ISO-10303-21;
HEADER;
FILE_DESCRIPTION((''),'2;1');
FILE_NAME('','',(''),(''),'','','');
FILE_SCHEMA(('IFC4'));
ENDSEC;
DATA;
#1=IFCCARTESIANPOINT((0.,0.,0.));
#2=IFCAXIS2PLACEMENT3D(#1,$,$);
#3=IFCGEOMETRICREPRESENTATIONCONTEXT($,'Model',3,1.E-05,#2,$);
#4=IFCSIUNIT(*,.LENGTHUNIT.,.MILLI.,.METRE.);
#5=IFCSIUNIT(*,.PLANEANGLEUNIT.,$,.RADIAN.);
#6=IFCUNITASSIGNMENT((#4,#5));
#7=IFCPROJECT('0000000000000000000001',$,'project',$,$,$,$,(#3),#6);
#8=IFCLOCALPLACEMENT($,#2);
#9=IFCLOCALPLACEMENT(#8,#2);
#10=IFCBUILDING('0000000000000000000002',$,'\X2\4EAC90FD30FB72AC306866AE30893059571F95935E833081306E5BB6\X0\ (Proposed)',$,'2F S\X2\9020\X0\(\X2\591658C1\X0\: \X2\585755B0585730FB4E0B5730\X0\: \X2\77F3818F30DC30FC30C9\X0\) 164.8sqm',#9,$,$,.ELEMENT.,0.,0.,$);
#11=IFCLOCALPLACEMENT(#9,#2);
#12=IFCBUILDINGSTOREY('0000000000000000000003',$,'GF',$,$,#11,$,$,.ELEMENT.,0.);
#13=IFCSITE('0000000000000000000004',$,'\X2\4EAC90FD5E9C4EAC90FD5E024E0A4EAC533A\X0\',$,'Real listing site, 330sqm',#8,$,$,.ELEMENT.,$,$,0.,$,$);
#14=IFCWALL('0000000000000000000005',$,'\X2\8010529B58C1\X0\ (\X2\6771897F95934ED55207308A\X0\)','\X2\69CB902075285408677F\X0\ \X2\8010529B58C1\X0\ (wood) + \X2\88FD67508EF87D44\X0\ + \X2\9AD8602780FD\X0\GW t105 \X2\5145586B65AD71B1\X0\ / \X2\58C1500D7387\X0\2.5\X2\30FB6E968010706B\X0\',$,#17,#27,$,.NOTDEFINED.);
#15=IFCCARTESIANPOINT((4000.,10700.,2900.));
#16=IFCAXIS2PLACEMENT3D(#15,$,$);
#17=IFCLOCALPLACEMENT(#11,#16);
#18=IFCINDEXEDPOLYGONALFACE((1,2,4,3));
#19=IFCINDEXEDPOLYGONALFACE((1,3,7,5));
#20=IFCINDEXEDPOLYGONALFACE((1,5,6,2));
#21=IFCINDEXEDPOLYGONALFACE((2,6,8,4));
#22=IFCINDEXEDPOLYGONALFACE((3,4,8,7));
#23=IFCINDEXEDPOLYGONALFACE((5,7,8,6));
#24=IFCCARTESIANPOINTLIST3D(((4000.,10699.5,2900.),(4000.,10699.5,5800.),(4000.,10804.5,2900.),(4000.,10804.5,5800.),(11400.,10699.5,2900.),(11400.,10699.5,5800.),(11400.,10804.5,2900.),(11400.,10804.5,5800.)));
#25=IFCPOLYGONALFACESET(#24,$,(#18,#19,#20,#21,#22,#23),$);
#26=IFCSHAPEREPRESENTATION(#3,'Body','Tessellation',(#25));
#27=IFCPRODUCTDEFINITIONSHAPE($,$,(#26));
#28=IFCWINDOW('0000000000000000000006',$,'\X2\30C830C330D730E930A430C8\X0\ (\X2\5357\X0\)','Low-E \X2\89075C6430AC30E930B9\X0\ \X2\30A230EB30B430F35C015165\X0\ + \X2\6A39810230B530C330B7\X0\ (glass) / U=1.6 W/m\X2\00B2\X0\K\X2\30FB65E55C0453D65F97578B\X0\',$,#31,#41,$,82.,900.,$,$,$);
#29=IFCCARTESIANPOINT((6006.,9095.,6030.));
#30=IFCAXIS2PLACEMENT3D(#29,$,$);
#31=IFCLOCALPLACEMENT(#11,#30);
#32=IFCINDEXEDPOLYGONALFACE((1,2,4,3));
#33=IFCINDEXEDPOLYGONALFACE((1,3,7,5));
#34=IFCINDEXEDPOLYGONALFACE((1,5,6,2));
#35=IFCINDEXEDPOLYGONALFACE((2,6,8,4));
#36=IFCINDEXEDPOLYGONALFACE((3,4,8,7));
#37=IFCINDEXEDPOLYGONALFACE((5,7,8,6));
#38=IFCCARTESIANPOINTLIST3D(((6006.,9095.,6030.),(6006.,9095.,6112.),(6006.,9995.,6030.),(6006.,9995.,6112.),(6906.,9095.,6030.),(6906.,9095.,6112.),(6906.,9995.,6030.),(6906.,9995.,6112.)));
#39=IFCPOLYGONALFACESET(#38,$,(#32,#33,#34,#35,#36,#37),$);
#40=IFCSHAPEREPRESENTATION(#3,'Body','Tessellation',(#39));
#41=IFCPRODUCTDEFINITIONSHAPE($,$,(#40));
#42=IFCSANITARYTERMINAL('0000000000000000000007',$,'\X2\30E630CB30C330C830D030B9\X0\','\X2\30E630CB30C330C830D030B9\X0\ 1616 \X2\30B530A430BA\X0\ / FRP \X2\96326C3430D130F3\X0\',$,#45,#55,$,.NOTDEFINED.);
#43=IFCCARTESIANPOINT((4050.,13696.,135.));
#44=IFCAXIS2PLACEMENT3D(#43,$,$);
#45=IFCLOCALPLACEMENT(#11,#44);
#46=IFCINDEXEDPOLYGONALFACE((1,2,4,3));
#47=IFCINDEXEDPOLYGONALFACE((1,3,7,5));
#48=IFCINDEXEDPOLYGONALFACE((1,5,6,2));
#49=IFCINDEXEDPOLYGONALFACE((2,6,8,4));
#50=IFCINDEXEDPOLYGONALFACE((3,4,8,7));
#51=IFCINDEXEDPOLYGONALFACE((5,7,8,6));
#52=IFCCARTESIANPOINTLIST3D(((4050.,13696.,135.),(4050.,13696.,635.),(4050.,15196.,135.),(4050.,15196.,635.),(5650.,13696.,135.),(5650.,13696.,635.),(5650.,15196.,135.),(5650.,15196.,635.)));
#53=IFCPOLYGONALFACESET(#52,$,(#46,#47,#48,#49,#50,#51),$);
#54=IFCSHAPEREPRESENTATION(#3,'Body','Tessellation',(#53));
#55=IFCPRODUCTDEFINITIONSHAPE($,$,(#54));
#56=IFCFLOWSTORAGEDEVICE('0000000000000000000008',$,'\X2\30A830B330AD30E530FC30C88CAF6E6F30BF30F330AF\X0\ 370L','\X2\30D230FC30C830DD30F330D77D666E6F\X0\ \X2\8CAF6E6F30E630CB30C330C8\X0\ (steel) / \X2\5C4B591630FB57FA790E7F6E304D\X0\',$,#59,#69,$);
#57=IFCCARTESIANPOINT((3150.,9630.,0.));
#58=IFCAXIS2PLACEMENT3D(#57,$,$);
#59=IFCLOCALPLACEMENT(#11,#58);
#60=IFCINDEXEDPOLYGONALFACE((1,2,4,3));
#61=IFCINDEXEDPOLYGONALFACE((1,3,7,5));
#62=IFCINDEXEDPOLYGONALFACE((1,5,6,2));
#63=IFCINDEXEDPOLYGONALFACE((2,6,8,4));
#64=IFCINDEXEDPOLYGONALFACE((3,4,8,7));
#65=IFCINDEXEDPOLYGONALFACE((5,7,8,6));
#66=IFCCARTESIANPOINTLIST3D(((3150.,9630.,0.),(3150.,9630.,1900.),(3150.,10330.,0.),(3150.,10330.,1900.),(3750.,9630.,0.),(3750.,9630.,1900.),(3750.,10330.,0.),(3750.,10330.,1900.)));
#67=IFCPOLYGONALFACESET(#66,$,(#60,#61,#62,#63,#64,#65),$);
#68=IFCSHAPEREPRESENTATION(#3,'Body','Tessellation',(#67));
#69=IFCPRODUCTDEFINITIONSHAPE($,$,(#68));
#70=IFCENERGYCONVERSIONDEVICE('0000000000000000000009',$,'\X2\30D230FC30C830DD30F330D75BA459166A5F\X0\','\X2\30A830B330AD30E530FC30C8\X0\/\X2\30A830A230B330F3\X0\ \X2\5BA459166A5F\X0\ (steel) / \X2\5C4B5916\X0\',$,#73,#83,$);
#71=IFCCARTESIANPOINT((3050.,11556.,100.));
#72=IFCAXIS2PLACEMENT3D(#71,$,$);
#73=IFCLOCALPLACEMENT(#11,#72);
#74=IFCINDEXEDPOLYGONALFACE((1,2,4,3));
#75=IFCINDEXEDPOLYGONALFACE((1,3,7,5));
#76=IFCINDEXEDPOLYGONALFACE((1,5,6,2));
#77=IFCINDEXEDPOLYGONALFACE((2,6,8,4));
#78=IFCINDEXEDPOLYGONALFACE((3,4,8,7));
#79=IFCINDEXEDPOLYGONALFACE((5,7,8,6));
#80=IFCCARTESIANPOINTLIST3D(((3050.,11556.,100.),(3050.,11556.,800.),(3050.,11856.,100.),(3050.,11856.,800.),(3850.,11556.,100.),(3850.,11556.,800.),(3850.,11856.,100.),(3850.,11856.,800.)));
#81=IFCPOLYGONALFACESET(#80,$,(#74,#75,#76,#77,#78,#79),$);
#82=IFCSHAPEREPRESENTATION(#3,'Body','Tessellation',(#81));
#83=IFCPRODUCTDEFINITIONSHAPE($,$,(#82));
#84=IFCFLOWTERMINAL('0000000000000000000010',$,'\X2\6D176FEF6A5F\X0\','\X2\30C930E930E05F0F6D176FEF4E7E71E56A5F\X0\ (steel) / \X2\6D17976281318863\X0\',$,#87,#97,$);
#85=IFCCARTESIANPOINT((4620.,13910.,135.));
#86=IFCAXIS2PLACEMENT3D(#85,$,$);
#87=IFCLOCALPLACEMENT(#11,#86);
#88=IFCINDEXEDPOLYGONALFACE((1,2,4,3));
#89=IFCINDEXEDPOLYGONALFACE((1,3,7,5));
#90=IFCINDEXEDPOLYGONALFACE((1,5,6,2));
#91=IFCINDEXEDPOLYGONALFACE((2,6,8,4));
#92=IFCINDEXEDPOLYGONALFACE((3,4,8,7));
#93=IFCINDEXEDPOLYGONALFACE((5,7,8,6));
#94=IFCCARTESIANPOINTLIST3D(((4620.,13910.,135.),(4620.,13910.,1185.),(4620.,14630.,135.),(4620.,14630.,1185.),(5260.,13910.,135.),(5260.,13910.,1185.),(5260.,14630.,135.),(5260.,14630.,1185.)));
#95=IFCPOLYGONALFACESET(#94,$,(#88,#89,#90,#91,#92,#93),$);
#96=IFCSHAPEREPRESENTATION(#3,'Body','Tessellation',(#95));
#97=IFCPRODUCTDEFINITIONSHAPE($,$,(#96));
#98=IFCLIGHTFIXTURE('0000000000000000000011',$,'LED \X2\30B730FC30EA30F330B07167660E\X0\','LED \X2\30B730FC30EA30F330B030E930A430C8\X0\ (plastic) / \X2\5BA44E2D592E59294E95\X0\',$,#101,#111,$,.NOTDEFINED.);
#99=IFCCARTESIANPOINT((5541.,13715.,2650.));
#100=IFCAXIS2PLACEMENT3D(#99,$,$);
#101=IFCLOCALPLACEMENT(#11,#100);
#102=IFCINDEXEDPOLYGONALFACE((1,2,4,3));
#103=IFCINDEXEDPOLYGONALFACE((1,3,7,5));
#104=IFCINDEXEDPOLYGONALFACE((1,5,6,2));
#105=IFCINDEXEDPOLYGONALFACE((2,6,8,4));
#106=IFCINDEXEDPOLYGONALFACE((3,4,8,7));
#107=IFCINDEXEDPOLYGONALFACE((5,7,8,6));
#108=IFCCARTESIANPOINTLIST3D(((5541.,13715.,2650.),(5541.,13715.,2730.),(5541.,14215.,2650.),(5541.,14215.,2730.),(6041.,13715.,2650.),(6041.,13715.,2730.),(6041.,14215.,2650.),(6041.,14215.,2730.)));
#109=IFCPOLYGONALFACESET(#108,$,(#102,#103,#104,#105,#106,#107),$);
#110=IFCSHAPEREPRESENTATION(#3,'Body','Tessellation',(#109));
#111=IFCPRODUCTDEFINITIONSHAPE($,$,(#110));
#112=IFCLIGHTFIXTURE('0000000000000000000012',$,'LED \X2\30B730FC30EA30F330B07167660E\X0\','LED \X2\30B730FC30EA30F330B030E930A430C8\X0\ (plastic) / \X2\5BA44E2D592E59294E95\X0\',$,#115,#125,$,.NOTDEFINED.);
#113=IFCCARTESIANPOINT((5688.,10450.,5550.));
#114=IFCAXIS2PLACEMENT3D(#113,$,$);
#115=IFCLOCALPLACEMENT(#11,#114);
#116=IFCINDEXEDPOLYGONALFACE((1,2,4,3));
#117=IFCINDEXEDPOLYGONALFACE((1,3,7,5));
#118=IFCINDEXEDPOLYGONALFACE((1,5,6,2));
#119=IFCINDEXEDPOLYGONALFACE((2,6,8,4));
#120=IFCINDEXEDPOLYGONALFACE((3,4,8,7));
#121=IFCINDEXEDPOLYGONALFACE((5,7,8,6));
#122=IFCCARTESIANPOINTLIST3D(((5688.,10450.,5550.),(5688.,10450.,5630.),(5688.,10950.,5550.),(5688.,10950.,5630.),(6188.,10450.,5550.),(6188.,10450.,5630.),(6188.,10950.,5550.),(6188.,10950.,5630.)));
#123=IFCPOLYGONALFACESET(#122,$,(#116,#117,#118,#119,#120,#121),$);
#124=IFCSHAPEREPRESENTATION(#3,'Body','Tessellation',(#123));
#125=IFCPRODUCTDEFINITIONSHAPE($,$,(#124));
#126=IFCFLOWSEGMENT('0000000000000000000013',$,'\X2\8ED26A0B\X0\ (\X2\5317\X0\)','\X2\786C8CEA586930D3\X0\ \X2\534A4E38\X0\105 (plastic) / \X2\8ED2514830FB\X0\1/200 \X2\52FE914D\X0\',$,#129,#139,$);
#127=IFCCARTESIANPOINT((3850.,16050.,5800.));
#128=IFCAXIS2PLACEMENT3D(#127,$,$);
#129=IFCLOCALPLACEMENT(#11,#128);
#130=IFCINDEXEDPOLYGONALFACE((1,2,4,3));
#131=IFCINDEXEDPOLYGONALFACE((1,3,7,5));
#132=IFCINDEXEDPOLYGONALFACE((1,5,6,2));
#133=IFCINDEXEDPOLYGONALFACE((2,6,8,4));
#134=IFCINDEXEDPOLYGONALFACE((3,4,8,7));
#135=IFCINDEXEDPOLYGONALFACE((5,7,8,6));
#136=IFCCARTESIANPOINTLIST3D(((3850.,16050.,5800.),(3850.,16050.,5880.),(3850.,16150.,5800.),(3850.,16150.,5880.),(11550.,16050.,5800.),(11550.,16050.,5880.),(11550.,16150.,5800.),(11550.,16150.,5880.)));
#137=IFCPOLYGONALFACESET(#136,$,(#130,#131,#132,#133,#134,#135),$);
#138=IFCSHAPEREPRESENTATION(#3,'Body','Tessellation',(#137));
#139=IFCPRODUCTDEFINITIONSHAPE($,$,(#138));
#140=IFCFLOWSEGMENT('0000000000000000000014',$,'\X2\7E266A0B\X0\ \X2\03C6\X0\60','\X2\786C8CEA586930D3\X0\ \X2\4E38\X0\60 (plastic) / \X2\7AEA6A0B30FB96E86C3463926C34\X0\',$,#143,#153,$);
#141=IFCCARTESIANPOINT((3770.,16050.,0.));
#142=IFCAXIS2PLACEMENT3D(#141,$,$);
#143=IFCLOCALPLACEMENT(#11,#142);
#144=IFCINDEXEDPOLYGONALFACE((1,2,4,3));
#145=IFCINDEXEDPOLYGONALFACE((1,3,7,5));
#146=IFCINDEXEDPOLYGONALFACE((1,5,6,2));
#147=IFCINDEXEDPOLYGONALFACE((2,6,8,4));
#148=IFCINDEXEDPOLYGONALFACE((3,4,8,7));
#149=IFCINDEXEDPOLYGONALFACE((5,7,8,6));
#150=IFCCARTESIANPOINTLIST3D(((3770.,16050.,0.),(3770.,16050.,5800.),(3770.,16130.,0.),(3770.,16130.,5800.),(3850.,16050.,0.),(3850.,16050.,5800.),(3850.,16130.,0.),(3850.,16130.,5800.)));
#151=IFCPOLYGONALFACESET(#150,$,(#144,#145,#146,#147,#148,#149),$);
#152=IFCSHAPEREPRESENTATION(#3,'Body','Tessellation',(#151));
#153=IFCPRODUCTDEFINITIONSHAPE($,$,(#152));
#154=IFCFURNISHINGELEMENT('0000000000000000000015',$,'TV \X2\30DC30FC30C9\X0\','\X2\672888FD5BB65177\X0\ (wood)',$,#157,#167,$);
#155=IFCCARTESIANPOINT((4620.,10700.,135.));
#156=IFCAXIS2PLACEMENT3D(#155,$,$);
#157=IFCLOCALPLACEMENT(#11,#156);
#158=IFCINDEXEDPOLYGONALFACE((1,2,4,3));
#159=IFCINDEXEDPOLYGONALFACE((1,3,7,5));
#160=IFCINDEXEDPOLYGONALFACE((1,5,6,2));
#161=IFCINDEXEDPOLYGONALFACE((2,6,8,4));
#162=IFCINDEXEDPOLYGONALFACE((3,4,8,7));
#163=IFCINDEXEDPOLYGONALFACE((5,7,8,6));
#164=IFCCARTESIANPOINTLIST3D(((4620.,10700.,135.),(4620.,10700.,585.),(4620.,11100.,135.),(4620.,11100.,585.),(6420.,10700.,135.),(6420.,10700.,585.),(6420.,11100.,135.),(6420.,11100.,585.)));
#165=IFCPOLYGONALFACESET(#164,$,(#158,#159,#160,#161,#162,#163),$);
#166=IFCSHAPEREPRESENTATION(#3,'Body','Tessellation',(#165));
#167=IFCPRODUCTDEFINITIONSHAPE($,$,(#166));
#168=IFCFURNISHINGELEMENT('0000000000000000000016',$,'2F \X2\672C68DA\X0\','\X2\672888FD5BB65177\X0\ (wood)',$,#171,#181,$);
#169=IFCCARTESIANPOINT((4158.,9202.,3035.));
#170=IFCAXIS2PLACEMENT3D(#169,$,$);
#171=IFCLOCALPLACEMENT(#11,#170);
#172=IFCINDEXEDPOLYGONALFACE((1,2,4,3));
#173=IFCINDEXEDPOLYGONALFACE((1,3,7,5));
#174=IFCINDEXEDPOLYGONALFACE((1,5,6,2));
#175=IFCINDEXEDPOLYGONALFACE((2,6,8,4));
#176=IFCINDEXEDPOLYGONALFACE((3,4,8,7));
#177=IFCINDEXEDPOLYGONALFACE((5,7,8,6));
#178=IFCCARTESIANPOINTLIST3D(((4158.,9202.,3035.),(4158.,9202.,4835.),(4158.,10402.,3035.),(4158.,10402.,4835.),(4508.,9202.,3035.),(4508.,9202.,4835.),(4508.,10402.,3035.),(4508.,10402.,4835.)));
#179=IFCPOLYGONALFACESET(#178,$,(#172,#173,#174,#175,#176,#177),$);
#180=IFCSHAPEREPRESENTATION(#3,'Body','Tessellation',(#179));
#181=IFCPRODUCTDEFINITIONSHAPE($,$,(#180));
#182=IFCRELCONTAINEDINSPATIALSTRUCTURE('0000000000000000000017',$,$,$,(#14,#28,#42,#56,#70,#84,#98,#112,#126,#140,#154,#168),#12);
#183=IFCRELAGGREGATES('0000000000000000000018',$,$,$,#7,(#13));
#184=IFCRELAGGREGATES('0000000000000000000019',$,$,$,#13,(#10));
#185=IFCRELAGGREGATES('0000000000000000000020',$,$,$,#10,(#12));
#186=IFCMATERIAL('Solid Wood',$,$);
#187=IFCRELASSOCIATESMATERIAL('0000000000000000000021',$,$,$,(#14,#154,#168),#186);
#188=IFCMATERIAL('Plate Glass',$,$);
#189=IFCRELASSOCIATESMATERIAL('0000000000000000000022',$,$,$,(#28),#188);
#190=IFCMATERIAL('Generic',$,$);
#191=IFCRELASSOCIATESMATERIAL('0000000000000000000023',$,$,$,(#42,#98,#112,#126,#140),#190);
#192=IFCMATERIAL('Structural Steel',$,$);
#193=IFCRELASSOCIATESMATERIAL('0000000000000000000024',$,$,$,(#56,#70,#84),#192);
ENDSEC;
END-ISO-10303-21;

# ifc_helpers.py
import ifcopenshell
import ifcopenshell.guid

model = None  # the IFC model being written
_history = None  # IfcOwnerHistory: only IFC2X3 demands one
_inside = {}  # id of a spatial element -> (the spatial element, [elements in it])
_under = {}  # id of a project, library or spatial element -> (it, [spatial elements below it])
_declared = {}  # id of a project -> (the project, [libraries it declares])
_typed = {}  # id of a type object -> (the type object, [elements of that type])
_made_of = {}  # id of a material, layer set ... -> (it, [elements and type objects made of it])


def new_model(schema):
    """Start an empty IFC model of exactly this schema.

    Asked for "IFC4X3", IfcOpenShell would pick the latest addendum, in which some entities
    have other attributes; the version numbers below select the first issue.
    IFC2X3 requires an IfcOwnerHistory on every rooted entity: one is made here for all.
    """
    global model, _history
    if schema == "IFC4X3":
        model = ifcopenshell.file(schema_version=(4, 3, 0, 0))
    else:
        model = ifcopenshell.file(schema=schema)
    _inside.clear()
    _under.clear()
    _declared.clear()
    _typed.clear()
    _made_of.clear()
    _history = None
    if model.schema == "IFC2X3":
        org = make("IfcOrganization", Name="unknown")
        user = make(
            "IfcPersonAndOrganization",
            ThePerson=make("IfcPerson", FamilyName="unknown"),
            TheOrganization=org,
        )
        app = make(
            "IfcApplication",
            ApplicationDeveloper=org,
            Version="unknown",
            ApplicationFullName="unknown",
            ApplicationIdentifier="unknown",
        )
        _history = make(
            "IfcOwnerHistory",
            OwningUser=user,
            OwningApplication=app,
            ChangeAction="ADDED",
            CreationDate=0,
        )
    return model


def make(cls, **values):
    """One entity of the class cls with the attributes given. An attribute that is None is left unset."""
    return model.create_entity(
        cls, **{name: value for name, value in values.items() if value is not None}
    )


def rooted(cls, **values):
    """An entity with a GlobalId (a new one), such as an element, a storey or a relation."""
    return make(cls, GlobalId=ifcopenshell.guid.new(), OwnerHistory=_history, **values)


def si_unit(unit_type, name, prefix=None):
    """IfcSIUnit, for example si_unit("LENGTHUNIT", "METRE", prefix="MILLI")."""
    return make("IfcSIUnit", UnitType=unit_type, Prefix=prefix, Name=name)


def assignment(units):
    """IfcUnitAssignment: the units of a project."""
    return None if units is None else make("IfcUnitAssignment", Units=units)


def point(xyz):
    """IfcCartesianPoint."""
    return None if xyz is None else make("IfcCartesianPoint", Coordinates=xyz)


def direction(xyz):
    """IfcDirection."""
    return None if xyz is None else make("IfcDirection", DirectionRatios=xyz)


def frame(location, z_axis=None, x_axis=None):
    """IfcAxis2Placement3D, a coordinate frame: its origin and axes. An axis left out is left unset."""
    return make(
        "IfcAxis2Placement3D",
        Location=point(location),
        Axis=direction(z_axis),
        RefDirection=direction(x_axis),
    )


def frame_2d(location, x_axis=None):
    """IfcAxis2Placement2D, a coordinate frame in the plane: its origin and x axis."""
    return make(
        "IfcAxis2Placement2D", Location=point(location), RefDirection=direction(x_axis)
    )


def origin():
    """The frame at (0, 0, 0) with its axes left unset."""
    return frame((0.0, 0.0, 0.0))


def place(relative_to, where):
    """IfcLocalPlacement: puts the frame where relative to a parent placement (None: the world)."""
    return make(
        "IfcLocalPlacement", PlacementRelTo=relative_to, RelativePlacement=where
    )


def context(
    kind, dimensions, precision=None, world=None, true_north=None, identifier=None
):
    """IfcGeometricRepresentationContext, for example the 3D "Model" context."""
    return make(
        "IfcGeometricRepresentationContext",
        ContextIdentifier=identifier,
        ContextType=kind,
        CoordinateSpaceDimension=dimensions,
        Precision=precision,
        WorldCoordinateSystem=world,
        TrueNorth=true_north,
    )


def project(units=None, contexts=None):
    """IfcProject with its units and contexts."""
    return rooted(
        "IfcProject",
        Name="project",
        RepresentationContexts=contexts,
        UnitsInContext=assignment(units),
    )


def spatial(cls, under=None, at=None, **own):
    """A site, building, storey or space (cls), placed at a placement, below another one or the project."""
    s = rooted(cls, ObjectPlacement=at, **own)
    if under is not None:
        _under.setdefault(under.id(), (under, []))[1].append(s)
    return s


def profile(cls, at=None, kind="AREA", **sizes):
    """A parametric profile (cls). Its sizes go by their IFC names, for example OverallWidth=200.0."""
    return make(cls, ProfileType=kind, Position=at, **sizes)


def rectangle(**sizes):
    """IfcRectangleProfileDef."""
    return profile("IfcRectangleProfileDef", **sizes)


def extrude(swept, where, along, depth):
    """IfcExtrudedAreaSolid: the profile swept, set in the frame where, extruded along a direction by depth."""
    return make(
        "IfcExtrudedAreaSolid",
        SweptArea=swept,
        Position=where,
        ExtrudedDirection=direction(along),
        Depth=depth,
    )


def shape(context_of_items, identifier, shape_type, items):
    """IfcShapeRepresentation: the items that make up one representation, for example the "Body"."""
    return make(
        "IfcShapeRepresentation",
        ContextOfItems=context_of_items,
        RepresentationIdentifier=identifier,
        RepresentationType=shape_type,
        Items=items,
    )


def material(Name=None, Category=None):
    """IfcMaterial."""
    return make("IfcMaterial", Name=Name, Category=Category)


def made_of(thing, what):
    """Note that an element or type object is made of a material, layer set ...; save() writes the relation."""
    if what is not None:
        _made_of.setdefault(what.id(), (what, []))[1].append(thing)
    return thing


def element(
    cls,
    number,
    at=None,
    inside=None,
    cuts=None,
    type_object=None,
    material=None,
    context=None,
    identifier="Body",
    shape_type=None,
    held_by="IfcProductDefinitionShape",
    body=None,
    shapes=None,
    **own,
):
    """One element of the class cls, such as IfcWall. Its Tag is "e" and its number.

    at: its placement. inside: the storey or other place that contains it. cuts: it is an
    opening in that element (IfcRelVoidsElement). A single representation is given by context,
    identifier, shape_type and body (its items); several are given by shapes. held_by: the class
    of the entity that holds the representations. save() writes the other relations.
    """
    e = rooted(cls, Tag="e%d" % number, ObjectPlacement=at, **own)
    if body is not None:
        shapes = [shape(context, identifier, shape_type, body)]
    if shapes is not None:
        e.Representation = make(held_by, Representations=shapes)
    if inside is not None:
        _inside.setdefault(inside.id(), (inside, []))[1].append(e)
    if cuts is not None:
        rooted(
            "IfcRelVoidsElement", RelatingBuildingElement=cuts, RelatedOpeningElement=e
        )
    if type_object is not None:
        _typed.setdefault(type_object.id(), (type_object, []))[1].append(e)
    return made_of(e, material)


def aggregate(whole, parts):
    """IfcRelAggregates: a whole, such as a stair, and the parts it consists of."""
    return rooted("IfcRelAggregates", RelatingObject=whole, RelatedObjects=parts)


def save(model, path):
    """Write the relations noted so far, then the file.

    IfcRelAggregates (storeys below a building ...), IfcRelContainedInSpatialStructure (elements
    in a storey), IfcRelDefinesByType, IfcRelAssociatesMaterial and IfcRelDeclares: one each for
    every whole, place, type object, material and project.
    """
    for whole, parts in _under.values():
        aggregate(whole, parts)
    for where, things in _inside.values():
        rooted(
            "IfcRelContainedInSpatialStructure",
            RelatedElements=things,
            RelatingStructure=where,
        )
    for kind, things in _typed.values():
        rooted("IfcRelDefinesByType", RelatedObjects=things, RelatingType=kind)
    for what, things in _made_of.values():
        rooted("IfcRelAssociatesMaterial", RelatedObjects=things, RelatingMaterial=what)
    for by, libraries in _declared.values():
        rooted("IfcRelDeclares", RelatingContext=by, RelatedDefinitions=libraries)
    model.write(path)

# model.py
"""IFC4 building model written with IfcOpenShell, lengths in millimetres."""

from ifc_helpers import new_model, si_unit, frame, frame_2d, origin, place, context, project, spatial, rectangle, extrude, material, element, save


model = new_model("IFC4")

# Units and contexts
model_context = context("Model", 3, precision=1e-05, world=origin())
ifc_project = project(units=[si_unit("LENGTHUNIT", "METRE", prefix="MILLI"), si_unit("PLANEANGLEUNIT", "RADIAN")], contexts=[model_context])

# Site, building, storey
site_placement = place(None, origin())
site = spatial("IfcSite", under=ifc_project, at=site_placement, Name="京都府京都市上京区", ObjectType="Real listing site, 330sqm", CompositionType="ELEMENT", RefElevation=0.0)
building_placement = place(site_placement, origin())
building = spatial("IfcBuilding", under=site, at=building_placement, Name="京都・犬と暮らす土間広めの家 (Proposed)", ObjectType="2F S造(外壁: 塗喰塗・下地: 石膏ボード) 164.8sqm", CompositionType="ELEMENT", ElevationOfRefHeight=0.0, ElevationOfTerrain=0.0)
storey_placement = place(building_placement, origin())
storey = spatial("IfcBuildingStorey", under=building, at=storey_placement, Name="GF", CompositionType="ELEMENT", Elevation=0.0)

# Shared definitions
ifc_material_1 = material(Name="Solid Wood")

# Shared definitions
ifc_material_2 = material(Name="Plate Glass")

# Wall
wall_1_placement = place(storey_placement, frame((4000.0, 10700.0, 2900.0)))
element("IfcWall", 1, at=wall_1_placement, inside=storey, material=ifc_material_1, Name="耐力壁 (東西間仕切り)", Description="構造用合板 耐力壁 (wood) + 製材軸組 + 高性能GW t105 充填断熱 / 壁倍率2.5・準耐火", PredefinedType="NOTDEFINED", context=model_context, shape_type="SweptSolid", body=[
    extrude(rectangle(XDim=7400.0, YDim=105.0, at=frame_2d((3700.0, 52.0))), frame((4000.0, 10700.0, 2900.0)), (0.0, 0.0, 1.0), 2900.0),
])

# Window
window_1_placement = place(storey_placement, frame((6006.0, 9095.0, 6030.0)))
element("IfcWindow", 2, at=window_1_placement, inside=storey, material=ifc_material_2, Name="トップライト (南)", Description="Low-E 複層ガラス アルゴン封入 + 樹脂サッシ (glass) / U=1.6 W/m²K・日射取得型", OverallHeight=82.0, OverallWidth=900.0, context=model_context, shape_type="SweptSolid", body=[
    extrude(rectangle(XDim=900.0, YDim=900.0, at=frame_2d((450.0, 450.0))), frame((6006.0, 9095.0, 6030.0)), (0.0, 0.0, 1.0), 82.0),
])

# Sanitary terminal
ifc_material_3 = material(Name="Generic")
sanitary_terminal_placement = place(storey_placement, frame((4050.0, 13696.0, 135.0)))
element("IfcSanitaryTerminal", 3, at=sanitary_terminal_placement, inside=storey, material=ifc_material_3, Name="ユニットバス", Description="ユニットバス 1616 サイズ / FRP 防水パン", PredefinedType="NOTDEFINED", context=model_context, shape_type="SweptSolid", body=[
    extrude(rectangle(XDim=1600.0, YDim=1500.0, at=frame_2d((800.0, 750.0))), frame((4050.0, 13696.0, 135.0)), (0.0, 0.0, 1.0), 500.0),
])

# Flow storage device
ifc_material_4 = material(Name="Structural Steel")
flow_storage_device_placement = place(storey_placement, frame((3150.0, 9630.0, 0.0)))
element("IfcFlowStorageDevice", 4, at=flow_storage_device_placement, inside=storey, material=ifc_material_4, Name="エコキュート貯湯タンク 370L", Description="ヒートポンプ給湯 貯湯ユニット (steel) / 屋外・基礎置き", context=model_context, shape_type="SweptSolid", body=[
    extrude(rectangle(XDim=600.0, YDim=700.0, at=frame_2d((300.0, 350.0))), frame((3150.0, 9630.0, 0.0)), (0.0, 0.0, 1.0), 1900.0),
])

# Energy conversion device
energy_conversion_device_placement = place(storey_placement, frame((3050.0, 11556.0, 100.0)))
element("IfcEnergyConversionDevice", 5, at=energy_conversion_device_placement, inside=storey, material=ifc_material_4, Name="ヒートポンプ室外機", Description="エコキュート/エアコン 室外機 (steel) / 屋外", context=model_context, shape_type="SweptSolid", body=[
    extrude(rectangle(XDim=800.0, YDim=300.0, at=frame_2d((400.0, 150.0))), frame((3050.0, 11556.0, 100.0)), (0.0, 0.0, 1.0), 700.0),
])

# Flow terminal
flow_terminal_placement = place(storey_placement, frame((4620.0, 13910.0, 135.0)))
element("IfcFlowTerminal", 6, at=flow_terminal_placement, inside=storey, material=ifc_material_4, Name="洗濯機", Description="ドラム式洗濯乾燥機 (steel) / 洗面脱衣", context=model_context, shape_type="SweptSolid", body=[
    extrude(rectangle(XDim=640.0, YDim=720.0, at=frame_2d((320.0, 360.0))), frame((4620.0, 13910.0, 135.0)), (0.0, 0.0, 1.0), 1050.0),
])

# Light fixtures
light_fixture_1_placement = place(storey_placement, frame((5541.0, 13715.0, 2650.0)))
element("IfcLightFixture", 7, at=light_fixture_1_placement, inside=storey, material=ifc_material_3, Name="LED シーリング照明", Description="LED シーリングライト (plastic) / 室中央天井", PredefinedType="NOTDEFINED", context=model_context, shape_type="SweptSolid", body=[
    extrude(rectangle(XDim=500.0, YDim=500.0, at=frame_2d((250.0, 250.0))), frame((5541.0, 13715.0, 2650.0)), (0.0, 0.0, 1.0), 80.0),
])
light_fixture_2_placement = place(storey_placement, frame((5688.0, 10450.0, 5550.0)))
element("IfcLightFixture", 8, at=light_fixture_2_placement, inside=storey, material=ifc_material_3, Name="LED シーリング照明", Description="LED シーリングライト (plastic) / 室中央天井", PredefinedType="NOTDEFINED", context=model_context, shape_type="SweptSolid", body=[
    extrude(rectangle(XDim=500.0, YDim=500.0, at=frame_2d((250.0, 250.0))), frame((5688.0, 10450.0, 5550.0)), (0.0, 0.0, 1.0), 80.0),
])

# Flow segments
flow_segment_1_placement = place(storey_placement, frame((3850.0, 16050.0, 5800.0)))
element("IfcFlowSegment", 9, at=flow_segment_1_placement, inside=storey, material=ifc_material_3, Name="軒樋 (北)", Description="硬質塩ビ 半丸105 (plastic) / 軒先・1/200 勾配", context=model_context, shape_type="SweptSolid", body=[
    extrude(rectangle(XDim=7700.0, YDim=100.0, at=frame_2d((3850.0, 50.0))), frame((3850.0, 16050.0, 5800.0)), (0.0, 0.0, 1.0), 80.0),
])
flow_segment_2_placement = place(storey_placement, frame((3770.0, 16050.0, 0.0)))
element("IfcFlowSegment", 10, at=flow_segment_2_placement, inside=storey, material=ifc_material_3, Name="縦樋 φ60", Description="硬質塩ビ 丸60 (plastic) / 竪樋・雨水排水", context=model_context, shape_type="SweptSolid", body=[
    extrude(rectangle(XDim=80.0, YDim=80.0, at=frame_2d((40.0, 40.0))), frame((3770.0, 16050.0, 0.0)), (0.0, 0.0, 1.0), 5800.0),
])

# Furnishing elements
furnishing_1_placement = place(storey_placement, frame((4620.0, 10700.0, 135.0)))
element("IfcFurnishingElement", 11, at=furnishing_1_placement, inside=storey, material=ifc_material_1, Name="TV ボード", Description="木製家具 (wood)", context=model_context, shape_type="SweptSolid", body=[
    extrude(rectangle(XDim=1800.0, YDim=400.0, at=frame_2d((900.0, 200.0))), frame((4620.0, 10700.0, 135.0)), (0.0, 0.0, 1.0), 450.0),
])
furnishing_2_placement = place(storey_placement, frame((4158.0, 9202.0, 3035.0)))
element("IfcFurnishingElement", 12, at=furnishing_2_placement, inside=storey, material=ifc_material_1, Name="2F 本棚", Description="木製家具 (wood)", context=model_context, shape_type="SweptSolid", body=[
    extrude(rectangle(XDim=350.0, YDim=1200.0, at=frame_2d((175.0, 600.0))), frame((4158.0, 9202.0, 3035.0)), (0.0, 0.0, 1.0), 1800.0),
])

save(model, "model.ifc")
